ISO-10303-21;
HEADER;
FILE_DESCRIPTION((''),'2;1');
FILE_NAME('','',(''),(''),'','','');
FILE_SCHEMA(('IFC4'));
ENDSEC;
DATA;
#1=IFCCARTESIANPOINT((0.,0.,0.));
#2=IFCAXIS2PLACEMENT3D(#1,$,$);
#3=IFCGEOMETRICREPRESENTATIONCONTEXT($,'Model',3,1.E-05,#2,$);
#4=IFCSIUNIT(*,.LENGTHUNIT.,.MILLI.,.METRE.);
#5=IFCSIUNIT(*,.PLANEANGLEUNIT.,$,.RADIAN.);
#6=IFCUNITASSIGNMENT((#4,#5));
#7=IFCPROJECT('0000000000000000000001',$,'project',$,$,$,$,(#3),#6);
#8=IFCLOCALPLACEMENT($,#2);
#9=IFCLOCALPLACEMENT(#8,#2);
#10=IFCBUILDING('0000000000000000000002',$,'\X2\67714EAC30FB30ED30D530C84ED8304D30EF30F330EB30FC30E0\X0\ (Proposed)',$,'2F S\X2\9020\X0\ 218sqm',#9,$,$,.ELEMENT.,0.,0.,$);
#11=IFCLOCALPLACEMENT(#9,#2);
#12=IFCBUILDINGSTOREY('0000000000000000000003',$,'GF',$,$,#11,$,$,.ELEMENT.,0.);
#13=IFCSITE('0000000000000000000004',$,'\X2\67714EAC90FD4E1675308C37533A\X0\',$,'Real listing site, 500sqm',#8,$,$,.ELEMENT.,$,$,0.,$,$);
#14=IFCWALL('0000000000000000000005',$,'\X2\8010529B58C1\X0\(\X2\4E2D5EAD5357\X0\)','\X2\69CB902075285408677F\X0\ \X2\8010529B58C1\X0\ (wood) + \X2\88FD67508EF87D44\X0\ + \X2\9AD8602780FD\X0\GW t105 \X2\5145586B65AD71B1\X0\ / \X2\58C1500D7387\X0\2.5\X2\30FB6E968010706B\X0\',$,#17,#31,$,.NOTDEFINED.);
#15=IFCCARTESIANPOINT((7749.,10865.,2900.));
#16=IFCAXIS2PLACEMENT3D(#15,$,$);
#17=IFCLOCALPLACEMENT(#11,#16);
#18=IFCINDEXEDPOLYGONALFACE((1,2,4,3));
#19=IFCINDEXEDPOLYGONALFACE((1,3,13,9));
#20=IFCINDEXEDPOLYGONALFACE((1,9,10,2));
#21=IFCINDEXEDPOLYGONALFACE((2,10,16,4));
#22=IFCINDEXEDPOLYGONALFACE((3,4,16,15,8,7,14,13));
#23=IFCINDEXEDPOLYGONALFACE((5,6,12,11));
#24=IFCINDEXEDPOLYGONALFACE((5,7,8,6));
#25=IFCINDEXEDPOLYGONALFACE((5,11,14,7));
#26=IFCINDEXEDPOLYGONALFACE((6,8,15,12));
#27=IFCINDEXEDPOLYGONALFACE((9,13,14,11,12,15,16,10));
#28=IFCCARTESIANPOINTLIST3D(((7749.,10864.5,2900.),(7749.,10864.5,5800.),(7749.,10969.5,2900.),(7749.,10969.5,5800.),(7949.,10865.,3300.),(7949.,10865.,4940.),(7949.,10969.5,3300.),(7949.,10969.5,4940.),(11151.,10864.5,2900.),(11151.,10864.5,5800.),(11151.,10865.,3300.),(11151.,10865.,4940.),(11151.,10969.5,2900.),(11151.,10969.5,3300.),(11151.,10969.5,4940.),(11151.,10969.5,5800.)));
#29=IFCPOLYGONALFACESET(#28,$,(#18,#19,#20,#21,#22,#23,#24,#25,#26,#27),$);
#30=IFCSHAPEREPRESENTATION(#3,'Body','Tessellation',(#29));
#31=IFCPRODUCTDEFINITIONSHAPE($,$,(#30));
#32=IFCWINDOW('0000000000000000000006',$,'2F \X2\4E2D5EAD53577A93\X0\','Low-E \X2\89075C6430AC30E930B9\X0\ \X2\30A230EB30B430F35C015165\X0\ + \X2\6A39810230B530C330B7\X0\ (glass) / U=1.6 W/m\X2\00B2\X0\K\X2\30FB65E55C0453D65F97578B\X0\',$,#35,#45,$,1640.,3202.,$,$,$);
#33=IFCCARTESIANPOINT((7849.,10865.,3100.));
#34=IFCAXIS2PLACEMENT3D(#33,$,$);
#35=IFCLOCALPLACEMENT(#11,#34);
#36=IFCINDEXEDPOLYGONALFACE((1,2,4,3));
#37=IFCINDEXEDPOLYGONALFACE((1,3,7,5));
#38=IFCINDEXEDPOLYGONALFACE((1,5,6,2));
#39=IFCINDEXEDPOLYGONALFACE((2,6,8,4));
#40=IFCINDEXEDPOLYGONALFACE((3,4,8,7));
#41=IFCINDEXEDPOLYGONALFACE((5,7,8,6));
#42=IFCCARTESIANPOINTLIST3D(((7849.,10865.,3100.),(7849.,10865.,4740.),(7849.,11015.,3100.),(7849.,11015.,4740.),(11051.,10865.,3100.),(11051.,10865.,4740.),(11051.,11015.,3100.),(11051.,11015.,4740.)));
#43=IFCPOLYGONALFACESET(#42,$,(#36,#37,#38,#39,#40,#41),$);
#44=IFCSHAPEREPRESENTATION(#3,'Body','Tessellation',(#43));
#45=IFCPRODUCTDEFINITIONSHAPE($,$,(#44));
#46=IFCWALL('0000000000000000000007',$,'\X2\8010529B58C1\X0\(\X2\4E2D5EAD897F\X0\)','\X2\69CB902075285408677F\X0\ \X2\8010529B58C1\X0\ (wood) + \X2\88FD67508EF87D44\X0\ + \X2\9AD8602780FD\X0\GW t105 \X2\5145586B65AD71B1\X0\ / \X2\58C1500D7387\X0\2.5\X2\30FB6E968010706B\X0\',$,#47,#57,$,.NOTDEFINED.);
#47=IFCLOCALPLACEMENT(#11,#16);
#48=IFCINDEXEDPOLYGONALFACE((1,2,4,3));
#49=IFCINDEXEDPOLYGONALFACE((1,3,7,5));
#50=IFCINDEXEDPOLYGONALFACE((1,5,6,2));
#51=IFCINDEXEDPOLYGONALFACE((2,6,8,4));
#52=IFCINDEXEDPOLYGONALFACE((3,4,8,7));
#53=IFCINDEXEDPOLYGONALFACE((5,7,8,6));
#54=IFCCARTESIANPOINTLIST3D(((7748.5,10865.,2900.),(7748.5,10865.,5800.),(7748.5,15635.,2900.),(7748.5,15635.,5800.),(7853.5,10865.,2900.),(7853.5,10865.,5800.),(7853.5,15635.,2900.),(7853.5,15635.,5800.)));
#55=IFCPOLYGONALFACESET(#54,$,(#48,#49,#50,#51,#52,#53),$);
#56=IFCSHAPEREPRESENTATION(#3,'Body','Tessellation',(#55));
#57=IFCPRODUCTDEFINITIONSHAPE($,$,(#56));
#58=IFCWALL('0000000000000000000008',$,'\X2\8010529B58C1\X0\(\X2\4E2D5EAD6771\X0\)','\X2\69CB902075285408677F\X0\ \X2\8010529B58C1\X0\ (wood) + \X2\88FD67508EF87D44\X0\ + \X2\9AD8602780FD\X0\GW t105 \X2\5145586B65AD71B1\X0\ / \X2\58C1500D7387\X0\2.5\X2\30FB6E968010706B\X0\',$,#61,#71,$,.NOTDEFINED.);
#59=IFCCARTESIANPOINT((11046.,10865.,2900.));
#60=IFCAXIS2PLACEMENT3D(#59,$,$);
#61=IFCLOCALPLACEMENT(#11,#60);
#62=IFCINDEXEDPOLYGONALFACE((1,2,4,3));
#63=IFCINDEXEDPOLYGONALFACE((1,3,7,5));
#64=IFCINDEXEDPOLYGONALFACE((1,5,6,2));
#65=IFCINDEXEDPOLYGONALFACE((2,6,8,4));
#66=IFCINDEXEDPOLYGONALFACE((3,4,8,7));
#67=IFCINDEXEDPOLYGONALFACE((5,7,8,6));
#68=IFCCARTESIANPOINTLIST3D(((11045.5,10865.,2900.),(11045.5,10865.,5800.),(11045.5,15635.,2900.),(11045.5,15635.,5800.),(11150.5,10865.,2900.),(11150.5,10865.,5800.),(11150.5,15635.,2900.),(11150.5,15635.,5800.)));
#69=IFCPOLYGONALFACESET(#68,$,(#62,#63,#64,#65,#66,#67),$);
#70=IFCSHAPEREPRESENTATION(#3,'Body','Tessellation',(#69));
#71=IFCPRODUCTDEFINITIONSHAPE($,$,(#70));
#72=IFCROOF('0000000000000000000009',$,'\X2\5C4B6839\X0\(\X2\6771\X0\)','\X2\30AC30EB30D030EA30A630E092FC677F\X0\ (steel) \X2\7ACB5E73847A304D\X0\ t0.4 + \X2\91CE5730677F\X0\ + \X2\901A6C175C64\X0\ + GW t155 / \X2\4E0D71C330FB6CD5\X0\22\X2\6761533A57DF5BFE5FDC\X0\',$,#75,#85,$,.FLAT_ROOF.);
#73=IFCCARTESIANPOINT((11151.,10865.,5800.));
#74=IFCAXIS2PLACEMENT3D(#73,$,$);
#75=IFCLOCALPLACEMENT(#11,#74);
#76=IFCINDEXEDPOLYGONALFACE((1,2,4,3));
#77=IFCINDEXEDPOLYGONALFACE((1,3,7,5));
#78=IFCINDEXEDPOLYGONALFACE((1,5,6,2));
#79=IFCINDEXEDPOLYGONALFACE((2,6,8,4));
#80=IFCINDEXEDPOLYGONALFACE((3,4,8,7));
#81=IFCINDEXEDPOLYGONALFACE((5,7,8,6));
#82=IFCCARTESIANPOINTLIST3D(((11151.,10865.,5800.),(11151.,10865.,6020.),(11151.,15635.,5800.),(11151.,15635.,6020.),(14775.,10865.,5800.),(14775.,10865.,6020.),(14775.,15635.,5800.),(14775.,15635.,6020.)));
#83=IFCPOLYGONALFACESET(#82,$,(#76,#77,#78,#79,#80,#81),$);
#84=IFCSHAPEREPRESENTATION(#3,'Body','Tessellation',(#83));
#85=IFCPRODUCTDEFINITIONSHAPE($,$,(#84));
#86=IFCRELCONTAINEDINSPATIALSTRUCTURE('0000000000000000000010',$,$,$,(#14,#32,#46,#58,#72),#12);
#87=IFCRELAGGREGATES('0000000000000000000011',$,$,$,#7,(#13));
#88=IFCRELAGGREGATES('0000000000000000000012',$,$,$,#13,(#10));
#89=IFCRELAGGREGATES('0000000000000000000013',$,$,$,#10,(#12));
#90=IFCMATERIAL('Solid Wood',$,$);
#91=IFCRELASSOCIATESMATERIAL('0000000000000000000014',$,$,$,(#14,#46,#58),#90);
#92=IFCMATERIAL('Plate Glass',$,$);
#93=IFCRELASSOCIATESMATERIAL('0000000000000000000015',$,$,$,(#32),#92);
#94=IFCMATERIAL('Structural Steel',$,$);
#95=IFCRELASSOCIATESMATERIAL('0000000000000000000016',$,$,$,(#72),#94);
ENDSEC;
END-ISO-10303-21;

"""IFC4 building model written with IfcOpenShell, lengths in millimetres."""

from ifc_helpers import new_model, si_unit, frame, frame_2d, origin, place, context, project, spatial, rectangle, extrude, material, element, fill, save


model = new_model("IFC4")

# Units and contexts
model_context = context("Model", 3, precision=1e-05, world=origin())
ifc_project = project(units=[si_unit("LENGTHUNIT", "METRE", prefix="MILLI"), si_unit("PLANEANGLEUNIT", "RADIAN")], contexts=[model_context])

# Site, building, storey
site_placement = place(None, origin())
site = spatial("IfcSite", under=ifc_project, at=site_placement, Name="東京都世田谷区", ObjectType="Real listing site, 500sqm", CompositionType="ELEMENT", RefElevation=0.0)
building_placement = place(site_placement, origin())
building = spatial("IfcBuilding", under=site, at=building_placement, Name="東京・ロフト付きワンルーム (Proposed)", ObjectType="2F S造 218sqm", CompositionType="ELEMENT", ElevationOfRefHeight=0.0, ElevationOfTerrain=0.0)
storey_placement = place(building_placement, origin())
storey = spatial("IfcBuildingStorey", under=building, at=storey_placement, Name="GF", CompositionType="ELEMENT", Elevation=0.0)

# Shared definitions
ifc_material_1 = material(Name="Solid Wood")

# Wall, opening, window
wall_1_placement = place(storey_placement, frame((7749.0, 10865.0, 2900.0)))
wall_1 = element("IfcWall", 1, at=wall_1_placement, inside=storey, material=ifc_material_1, Name="耐力壁(中庭南)", Description="構造用合板 耐力壁 (wood) + 製材軸組 + 高性能GW t105 充填断熱 / 壁倍率2.5・準耐火", PredefinedType="NOTDEFINED", context=model_context, shape_type="SweptSolid", body=[
    extrude(rectangle(XDim=3402.0, YDim=105.0, at=frame_2d((1701.0, 52.0))), frame((7749.0, 10865.0, 2900.0)), (0.0, 0.0, 1.0), 2900.0),
])
opening_placement = place(storey_placement, frame((7849.0, 10865.0, 3100.0)))
opening = element("IfcOpeningElement", 2, at=opening_placement, cuts=wall_1, PredefinedType="NOTDEFINED", context=model_context, shape_type="SweptSolid", body=[
    extrude(rectangle(XDim=3202.0, YDim=150.0, at=frame_2d((1601.0, 75.0))), frame((7849.0, 10865.0, 3100.0)), (0.0, 0.0, 1.0), 1640.0),
])
ifc_material_2 = material(Name="Plate Glass")
window_placement = place(storey_placement, frame((7849.0, 10865.0, 3100.0)))
window = element("IfcWindow", 3, at=window_placement, inside=storey, material=ifc_material_2, Name="2F 中庭南窓", Description="Low-E 複層ガラス アルゴン封入 + 樹脂サッシ (glass) / U=1.6 W/m²K・日射取得型", OverallHeight=1640.0, OverallWidth=3202.0, context=model_context, shape_type="SweptSolid", body=[
    extrude(rectangle(XDim=3202.0, YDim=150.0, at=frame_2d((1601.0, 75.0))), frame((7849.0, 10865.0, 3100.0)), (0.0, 0.0, 1.0), 1640.0),
])
fill(opening, window)

# Walls
wall_2_placement = place(storey_placement, frame((7749.0, 10865.0, 2900.0)))
element("IfcWall", 4, at=wall_2_placement, inside=storey, material=ifc_material_1, Name="耐力壁(中庭西)", Description="構造用合板 耐力壁 (wood) + 製材軸組 + 高性能GW t105 充填断熱 / 壁倍率2.5・準耐火", PredefinedType="NOTDEFINED", context=model_context, shape_type="SweptSolid", body=[
    extrude(rectangle(XDim=105.0, YDim=4770.0, at=frame_2d((52.0, 2385.0))), frame((7749.0, 10865.0, 2900.0)), (0.0, 0.0, 1.0), 2900.0),
])
wall_3_placement = place(storey_placement, frame((11046.0, 10865.0, 2900.0)))
element("IfcWall", 5, at=wall_3_placement, inside=storey, material=ifc_material_1, Name="耐力壁(中庭東)", Description="構造用合板 耐力壁 (wood) + 製材軸組 + 高性能GW t105 充填断熱 / 壁倍率2.5・準耐火", PredefinedType="NOTDEFINED", context=model_context, shape_type="SweptSolid", body=[
    extrude(rectangle(XDim=105.0, YDim=4770.0, at=frame_2d((52.0, 2385.0))), frame((11046.0, 10865.0, 2900.0)), (0.0, 0.0, 1.0), 2900.0),
])

# Roof
ifc_material_3 = material(Name="Structural Steel")
for number, where, name in (
    (6, (11151.0, 10865.0, 5800.0), "屋根(東)"),
):
    element("IfcRoof", number, at=place(storey_placement, frame(where)), inside=storey, material=ifc_material_3, Name=name, Description="ガルバリウム鋼板 (steel) 立平葺き t0.4 + 野地板 + 通気層 + GW t155 / 不燃・法22条区域対応", PredefinedType="FLAT_ROOF", context=model_context, shape_type="SweptSolid", body=[
        extrude(rectangle(XDim=3624.0, YDim=4770.0, at=frame_2d((1812.0, 2385.0))), frame((11151.0, 10865.0, 5800.0)), (0.0, 0.0, 1.0), 220.0),
    ])

save(model, "model.ifc")
